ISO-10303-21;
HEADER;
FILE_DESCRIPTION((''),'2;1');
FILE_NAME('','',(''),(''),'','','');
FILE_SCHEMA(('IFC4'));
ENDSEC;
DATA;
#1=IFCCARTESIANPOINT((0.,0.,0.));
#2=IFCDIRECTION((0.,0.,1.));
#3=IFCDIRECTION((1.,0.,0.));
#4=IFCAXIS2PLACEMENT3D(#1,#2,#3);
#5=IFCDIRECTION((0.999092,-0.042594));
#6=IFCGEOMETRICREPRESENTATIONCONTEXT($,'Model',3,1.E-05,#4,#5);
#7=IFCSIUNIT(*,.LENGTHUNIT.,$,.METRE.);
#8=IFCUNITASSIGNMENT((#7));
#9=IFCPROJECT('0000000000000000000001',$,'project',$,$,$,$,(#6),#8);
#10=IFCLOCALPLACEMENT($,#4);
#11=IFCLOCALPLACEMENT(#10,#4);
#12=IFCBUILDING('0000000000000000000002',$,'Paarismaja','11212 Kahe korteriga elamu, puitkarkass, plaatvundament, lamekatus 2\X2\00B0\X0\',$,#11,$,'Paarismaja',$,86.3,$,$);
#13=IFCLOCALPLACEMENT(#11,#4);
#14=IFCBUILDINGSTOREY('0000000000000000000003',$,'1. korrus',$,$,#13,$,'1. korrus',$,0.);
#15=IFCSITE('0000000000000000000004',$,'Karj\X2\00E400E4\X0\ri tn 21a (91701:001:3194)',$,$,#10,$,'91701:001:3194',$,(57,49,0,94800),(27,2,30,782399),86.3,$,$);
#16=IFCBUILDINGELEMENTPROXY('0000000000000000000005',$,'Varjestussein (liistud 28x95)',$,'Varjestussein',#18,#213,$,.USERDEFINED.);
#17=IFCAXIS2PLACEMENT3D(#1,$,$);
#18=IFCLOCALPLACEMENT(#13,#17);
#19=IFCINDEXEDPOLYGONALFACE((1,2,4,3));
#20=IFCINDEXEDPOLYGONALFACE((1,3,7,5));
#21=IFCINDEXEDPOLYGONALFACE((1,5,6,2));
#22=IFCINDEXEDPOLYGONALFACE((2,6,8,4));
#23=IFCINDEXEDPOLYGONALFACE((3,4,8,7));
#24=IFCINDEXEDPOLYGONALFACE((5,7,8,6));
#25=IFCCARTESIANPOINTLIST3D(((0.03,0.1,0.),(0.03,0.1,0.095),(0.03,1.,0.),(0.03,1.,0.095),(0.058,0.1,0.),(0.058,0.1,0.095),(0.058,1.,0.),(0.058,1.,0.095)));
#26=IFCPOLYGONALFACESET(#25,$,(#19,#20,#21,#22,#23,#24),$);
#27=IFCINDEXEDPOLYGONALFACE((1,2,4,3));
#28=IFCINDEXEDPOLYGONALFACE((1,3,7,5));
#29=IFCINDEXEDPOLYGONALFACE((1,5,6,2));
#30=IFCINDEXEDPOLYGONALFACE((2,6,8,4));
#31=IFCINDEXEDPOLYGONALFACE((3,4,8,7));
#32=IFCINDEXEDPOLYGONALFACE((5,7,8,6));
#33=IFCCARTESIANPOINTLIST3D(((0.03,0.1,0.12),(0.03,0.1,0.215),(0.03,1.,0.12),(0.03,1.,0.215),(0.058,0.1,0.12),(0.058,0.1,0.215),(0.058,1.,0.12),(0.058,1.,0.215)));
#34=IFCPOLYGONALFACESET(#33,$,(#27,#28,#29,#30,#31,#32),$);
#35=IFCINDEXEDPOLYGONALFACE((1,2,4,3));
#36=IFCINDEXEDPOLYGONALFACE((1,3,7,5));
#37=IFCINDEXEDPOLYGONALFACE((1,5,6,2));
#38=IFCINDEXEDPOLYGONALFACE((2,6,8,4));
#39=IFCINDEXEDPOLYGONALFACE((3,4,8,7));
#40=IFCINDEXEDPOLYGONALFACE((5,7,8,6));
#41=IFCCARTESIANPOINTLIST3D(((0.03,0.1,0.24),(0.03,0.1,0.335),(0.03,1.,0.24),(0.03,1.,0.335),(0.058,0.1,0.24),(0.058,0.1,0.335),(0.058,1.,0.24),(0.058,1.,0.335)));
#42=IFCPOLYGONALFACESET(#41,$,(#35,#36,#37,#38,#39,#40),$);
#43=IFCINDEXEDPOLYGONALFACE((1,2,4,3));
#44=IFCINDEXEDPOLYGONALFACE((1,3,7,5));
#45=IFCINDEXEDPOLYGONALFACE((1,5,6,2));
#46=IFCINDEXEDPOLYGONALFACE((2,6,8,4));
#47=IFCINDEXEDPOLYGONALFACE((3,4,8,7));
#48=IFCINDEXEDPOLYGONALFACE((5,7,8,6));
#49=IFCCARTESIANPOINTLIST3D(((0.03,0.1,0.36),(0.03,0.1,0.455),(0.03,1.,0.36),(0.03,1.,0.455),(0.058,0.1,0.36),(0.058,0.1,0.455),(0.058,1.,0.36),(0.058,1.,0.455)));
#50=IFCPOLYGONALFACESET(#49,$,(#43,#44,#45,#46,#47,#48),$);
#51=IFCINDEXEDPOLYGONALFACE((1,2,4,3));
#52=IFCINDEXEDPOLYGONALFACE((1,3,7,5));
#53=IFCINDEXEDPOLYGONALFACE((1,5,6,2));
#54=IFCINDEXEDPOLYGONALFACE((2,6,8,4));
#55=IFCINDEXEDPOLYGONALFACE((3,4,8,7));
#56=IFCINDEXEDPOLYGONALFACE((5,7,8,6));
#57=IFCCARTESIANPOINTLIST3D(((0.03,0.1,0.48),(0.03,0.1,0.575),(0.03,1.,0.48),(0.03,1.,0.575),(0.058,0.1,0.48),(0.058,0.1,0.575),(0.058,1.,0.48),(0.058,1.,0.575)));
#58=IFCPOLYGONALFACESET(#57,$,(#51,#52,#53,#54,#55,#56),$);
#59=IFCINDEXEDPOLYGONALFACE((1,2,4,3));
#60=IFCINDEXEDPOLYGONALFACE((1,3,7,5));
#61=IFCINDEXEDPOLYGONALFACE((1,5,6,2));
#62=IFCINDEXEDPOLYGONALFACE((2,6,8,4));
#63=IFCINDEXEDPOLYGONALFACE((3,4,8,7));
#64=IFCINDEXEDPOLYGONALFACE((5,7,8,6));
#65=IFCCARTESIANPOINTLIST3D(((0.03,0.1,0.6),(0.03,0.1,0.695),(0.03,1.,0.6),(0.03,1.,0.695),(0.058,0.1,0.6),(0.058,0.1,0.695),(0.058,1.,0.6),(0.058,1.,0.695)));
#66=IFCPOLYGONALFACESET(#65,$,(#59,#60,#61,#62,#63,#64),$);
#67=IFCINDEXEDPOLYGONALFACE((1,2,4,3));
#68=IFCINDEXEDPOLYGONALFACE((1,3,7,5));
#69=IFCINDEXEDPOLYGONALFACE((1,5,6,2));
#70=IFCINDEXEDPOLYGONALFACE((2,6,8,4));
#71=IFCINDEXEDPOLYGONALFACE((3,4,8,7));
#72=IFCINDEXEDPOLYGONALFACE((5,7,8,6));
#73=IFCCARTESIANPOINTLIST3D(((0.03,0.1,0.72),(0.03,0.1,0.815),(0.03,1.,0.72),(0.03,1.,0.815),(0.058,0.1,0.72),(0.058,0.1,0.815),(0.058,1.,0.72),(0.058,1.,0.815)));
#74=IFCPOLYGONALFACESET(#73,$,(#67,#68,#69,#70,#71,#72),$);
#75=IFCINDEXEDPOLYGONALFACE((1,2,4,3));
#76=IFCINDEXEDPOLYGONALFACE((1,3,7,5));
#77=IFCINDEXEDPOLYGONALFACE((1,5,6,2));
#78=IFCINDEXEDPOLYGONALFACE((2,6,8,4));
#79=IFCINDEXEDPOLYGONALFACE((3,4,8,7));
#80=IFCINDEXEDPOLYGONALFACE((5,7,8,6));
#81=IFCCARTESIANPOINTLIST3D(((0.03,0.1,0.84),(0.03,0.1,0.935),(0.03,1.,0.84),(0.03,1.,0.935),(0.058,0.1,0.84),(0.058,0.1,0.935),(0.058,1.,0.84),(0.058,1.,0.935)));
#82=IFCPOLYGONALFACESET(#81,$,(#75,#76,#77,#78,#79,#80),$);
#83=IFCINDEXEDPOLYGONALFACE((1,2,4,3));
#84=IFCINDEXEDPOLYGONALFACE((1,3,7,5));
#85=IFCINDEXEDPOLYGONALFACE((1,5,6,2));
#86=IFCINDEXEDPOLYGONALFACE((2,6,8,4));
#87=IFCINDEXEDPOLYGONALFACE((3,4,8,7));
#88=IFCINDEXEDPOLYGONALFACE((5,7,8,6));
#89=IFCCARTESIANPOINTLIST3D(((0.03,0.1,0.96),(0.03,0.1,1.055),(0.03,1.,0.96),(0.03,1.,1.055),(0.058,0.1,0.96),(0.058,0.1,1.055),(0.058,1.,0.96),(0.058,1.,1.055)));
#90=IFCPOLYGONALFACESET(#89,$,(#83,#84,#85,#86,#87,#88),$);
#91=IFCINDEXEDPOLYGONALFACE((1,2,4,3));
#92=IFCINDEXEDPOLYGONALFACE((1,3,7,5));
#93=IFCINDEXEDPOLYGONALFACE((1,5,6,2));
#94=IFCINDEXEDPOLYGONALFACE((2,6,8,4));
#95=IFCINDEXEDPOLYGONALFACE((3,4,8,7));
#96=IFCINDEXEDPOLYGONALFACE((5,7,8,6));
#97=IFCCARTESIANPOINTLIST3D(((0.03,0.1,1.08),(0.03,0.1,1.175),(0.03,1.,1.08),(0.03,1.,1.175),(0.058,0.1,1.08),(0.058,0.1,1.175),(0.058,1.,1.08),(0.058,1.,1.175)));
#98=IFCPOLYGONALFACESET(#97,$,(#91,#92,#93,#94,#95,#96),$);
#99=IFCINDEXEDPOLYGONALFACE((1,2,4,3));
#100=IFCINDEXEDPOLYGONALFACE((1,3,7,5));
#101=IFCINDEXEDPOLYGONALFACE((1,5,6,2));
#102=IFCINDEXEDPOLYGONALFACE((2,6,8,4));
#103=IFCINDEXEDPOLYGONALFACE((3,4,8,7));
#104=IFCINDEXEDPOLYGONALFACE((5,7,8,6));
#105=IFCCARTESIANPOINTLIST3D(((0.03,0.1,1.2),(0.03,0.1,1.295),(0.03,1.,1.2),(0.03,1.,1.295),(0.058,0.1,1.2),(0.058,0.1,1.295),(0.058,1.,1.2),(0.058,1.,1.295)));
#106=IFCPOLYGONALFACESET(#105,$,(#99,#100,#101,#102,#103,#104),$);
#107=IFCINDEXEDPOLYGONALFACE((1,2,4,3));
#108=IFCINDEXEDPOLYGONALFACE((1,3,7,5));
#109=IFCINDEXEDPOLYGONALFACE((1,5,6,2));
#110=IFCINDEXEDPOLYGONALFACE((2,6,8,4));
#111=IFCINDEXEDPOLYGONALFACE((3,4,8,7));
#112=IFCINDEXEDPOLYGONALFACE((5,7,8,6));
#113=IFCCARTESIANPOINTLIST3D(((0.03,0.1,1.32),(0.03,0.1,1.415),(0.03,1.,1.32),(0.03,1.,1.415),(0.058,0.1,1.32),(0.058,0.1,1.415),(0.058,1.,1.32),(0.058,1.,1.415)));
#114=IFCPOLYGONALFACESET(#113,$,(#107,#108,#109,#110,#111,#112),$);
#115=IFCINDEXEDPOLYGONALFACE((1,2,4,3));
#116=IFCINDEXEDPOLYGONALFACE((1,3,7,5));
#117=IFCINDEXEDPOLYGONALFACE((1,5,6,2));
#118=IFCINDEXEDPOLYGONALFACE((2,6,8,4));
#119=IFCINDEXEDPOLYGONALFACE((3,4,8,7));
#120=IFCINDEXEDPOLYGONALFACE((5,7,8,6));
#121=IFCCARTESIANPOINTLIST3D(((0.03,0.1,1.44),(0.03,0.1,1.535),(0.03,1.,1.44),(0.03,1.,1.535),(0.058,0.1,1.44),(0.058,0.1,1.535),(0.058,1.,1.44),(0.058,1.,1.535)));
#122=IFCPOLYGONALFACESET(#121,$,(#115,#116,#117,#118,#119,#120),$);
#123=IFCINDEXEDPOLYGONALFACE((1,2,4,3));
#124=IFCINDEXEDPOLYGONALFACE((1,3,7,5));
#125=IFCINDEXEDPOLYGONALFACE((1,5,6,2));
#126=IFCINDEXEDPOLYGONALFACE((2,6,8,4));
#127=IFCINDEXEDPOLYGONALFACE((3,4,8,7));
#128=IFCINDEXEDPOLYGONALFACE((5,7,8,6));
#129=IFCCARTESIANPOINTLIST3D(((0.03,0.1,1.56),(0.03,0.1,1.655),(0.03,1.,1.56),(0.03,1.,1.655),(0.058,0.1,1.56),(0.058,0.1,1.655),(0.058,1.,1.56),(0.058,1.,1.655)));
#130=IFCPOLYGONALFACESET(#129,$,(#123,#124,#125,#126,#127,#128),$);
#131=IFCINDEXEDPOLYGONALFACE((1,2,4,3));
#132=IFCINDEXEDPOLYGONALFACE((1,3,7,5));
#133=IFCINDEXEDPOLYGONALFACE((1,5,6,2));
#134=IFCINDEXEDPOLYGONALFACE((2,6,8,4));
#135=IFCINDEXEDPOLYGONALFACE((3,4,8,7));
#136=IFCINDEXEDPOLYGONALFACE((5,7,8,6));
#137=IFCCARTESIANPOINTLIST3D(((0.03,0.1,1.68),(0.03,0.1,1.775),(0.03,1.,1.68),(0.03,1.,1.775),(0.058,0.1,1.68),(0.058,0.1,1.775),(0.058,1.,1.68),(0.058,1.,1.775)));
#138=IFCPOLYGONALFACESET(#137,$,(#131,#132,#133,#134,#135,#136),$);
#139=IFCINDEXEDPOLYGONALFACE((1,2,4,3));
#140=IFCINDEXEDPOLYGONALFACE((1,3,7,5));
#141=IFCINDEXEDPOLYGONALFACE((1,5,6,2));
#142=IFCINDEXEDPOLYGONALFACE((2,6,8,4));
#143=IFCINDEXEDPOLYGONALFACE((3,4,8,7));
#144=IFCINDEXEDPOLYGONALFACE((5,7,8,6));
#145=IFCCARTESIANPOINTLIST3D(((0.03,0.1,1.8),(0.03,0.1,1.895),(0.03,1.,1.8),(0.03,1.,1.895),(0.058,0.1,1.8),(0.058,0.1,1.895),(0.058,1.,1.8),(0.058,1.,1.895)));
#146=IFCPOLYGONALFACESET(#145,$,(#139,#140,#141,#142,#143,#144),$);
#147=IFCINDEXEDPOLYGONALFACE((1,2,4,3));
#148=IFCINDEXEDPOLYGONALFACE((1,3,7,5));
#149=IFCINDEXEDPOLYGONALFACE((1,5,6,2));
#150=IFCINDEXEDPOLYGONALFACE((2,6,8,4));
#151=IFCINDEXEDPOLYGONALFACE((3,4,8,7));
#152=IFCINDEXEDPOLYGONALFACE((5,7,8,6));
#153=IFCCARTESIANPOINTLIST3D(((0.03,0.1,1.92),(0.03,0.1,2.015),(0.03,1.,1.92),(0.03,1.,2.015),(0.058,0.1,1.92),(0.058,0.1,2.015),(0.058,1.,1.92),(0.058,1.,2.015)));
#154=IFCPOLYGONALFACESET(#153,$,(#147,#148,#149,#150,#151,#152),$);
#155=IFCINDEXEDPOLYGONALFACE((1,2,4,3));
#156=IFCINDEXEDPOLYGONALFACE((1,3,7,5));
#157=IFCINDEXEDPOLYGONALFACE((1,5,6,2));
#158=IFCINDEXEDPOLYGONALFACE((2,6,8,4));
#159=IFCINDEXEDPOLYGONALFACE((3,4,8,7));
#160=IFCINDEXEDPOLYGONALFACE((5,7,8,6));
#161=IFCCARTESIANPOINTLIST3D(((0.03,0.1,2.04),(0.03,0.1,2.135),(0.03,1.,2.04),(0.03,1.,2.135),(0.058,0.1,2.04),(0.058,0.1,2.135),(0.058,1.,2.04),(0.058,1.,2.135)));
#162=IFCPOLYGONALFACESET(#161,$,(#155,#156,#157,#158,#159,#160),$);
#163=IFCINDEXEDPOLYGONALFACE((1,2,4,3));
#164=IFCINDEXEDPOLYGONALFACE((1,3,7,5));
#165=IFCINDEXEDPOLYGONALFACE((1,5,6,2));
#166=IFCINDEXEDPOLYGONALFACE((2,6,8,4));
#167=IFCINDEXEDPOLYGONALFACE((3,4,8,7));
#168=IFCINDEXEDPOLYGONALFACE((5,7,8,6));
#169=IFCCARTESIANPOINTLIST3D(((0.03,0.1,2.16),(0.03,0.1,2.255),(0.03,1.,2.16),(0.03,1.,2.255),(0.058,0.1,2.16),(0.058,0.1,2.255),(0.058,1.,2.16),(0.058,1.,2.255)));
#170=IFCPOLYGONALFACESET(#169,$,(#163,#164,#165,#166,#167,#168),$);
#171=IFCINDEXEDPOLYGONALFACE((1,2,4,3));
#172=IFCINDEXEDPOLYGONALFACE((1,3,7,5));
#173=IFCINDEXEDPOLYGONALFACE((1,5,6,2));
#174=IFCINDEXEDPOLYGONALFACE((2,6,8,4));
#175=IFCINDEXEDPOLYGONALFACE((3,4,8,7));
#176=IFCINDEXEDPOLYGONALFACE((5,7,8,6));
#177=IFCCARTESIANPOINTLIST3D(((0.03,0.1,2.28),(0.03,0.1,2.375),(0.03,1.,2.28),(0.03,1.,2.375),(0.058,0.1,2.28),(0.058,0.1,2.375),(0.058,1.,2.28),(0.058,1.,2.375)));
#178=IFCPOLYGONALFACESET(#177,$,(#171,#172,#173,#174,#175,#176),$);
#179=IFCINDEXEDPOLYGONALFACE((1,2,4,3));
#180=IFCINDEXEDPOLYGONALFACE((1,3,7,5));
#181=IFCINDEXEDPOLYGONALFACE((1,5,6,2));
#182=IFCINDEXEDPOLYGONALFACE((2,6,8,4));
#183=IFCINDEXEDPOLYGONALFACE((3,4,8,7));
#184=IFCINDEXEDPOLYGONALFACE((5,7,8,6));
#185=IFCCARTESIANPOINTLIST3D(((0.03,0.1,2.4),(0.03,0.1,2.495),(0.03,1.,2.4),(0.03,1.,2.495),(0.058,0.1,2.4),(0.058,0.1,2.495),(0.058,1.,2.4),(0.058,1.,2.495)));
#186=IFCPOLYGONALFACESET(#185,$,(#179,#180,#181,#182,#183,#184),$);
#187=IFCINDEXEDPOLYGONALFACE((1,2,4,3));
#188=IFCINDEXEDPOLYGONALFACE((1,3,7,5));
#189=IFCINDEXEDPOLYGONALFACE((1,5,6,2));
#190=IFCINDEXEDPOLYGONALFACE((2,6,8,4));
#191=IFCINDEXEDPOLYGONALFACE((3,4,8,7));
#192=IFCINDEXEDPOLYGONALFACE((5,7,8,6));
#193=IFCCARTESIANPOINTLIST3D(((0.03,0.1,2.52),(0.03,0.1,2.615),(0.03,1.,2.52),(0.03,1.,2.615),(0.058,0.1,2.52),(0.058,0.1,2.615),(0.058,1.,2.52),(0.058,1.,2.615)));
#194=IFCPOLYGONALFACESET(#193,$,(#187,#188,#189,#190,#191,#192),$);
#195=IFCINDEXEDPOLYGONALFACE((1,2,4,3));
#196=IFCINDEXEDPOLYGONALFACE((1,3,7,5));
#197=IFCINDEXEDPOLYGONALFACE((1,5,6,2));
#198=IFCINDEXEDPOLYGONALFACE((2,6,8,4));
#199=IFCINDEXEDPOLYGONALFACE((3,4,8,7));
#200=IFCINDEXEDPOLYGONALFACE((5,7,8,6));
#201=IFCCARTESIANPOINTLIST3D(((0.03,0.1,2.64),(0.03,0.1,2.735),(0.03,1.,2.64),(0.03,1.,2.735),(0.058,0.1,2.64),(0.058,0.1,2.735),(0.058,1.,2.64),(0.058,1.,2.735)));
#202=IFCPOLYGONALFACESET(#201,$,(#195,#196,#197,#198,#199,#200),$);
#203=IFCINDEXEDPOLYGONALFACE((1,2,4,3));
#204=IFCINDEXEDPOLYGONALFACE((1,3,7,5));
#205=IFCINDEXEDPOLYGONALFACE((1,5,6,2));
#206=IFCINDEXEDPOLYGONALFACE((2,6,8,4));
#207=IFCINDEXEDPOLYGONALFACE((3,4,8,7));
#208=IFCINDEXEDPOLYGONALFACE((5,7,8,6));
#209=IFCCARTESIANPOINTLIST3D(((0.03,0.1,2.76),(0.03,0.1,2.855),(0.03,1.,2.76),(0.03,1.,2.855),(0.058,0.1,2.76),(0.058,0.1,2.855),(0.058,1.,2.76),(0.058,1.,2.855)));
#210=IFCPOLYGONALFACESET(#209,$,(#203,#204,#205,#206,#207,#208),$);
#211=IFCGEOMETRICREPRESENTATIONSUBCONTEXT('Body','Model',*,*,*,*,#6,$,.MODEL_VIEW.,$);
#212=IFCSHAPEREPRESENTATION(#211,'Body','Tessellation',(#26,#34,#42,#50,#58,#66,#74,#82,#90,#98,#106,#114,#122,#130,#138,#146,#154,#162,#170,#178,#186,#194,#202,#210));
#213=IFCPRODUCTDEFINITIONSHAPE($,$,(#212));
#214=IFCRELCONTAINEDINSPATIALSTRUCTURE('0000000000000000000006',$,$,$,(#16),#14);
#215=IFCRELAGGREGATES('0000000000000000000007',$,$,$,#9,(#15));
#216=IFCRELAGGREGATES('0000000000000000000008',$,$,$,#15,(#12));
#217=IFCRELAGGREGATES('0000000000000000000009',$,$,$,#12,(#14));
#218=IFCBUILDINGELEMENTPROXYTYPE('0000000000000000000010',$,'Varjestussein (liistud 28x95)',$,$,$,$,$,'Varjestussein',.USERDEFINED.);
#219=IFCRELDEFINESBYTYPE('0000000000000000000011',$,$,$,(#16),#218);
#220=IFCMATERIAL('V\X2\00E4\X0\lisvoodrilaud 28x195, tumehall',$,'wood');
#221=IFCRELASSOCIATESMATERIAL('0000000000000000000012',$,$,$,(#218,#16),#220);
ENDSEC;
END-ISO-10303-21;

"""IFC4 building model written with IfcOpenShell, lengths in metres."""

from ifc_helpers import new_model, si_unit, direction, frame, origin_with_axes, place, context, subcontext, project, spatial, indexed_curve, outline, extrude, material, type_object, element, save


model = new_model("IFC4")

# Units and contexts
model_context = context("Model", 3, precision=1e-05, world=origin_with_axes(), true_north=direction((0.999092, -0.042594)))
body_context = subcontext(model_context, "Body", "Model", "MODEL_VIEW")
ifc_project = project(units=[si_unit("LENGTHUNIT", "METRE")], contexts=[model_context])

# Site, building, storey
site_placement = place(None, origin_with_axes())
site = spatial("IfcSite", under=ifc_project, at=site_placement, Name="Karjääri tn 21a (91701:001:3194)", LongName="91701:001:3194", RefLatitude=(57, 49, 0, 94800), RefLongitude=(27, 2, 30, 782399), RefElevation=86.3)
building_placement = place(site_placement, origin_with_axes())
building = spatial("IfcBuilding", under=site, at=building_placement, Name="Paarismaja", Description="11212 Kahe korteriga elamu, puitkarkass, plaatvundament, lamekatus 2°", LongName="Paarismaja", ElevationOfRefHeight=86.3)
storey_placement = place(building_placement, origin_with_axes())
storey = spatial("IfcBuildingStorey", under=building, at=storey_placement, Name="1. korrus", LongName="1. korrus", Elevation=0.0)

# Building element proxy
ifc_material_1 = material(Name="Välisvoodrilaud 28x195, tumehall", Category="wood")
building_element_proxy_type_1 = type_object("IfcBuildingElementProxyType", Name="Varjestussein (liistud 28x95)", ElementType="Varjestussein", PredefinedType="USERDEFINED", material=ifc_material_1)
proxy_1_placement = place(storey_placement, origin_with_axes())
element("IfcBuildingElementProxy", 1, at=proxy_1_placement, inside=storey, type_object=building_element_proxy_type_1, material=ifc_material_1, Name="Varjestussein (liistud 28x95)", ObjectType="Varjestussein", PredefinedType="USERDEFINED", context=body_context, shape_type="SweptSolid", body=[
    extrude(outline(indexed_curve([(0.03, 0.1), (0.058, 0.1), (0.058, 1.0), (0.03, 1.0), (0.03, 0.1)], self_intersect=False)), origin_with_axes(), (0.0, 0.0, 1.0), 0.095),
    extrude(outline(indexed_curve([(0.03, 0.1), (0.058, 0.1), (0.058, 1.0), (0.03, 1.0), (0.03, 0.1)], self_intersect=False)), frame((0.0, 0.0, 0.12), z_axis=(0.0, 0.0, 1.0), x_axis=(1.0, 0.0, 0.0)), (0.0, 0.0, 1.0), 0.095),
    extrude(outline(indexed_curve([(0.03, 0.1), (0.058, 0.1), (0.058, 1.0), (0.03, 1.0), (0.03, 0.1)], self_intersect=False)), frame((0.0, 0.0, 0.24), z_axis=(0.0, 0.0, 1.0), x_axis=(1.0, 0.0, 0.0)), (0.0, 0.0, 1.0), 0.095),
    extrude(outline(indexed_curve([(0.03, 0.1), (0.058, 0.1), (0.058, 1.0), (0.03, 1.0), (0.03, 0.1)], self_intersect=False)), frame((0.0, 0.0, 0.36), z_axis=(0.0, 0.0, 1.0), x_axis=(1.0, 0.0, 0.0)), (0.0, 0.0, 1.0), 0.095),
    extrude(outline(indexed_curve([(0.03, 0.1), (0.058, 0.1), (0.058, 1.0), (0.03, 1.0), (0.03, 0.1)], self_intersect=False)), frame((0.0, 0.0, 0.48), z_axis=(0.0, 0.0, 1.0), x_axis=(1.0, 0.0, 0.0)), (0.0, 0.0, 1.0), 0.095),
    extrude(outline(indexed_curve([(0.03, 0.1), (0.058, 0.1), (0.058, 1.0), (0.03, 1.0), (0.03, 0.1)], self_intersect=False)), frame((0.0, 0.0, 0.6), z_axis=(0.0, 0.0, 1.0), x_axis=(1.0, 0.0, 0.0)), (0.0, 0.0, 1.0), 0.095),
    extrude(outline(indexed_curve([(0.03, 0.1), (0.058, 0.1), (0.058, 1.0), (0.03, 1.0), (0.03, 0.1)], self_intersect=False)), frame((0.0, 0.0, 0.72), z_axis=(0.0, 0.0, 1.0), x_axis=(1.0, 0.0, 0.0)), (0.0, 0.0, 1.0), 0.095),
    extrude(outline(indexed_curve([(0.03, 0.1), (0.058, 0.1), (0.058, 1.0), (0.03, 1.0), (0.03, 0.1)], self_intersect=False)), frame((0.0, 0.0, 0.84), z_axis=(0.0, 0.0, 1.0), x_axis=(1.0, 0.0, 0.0)), (0.0, 0.0, 1.0), 0.095),
    extrude(outline(indexed_curve([(0.03, 0.1), (0.058, 0.1), (0.058, 1.0), (0.03, 1.0), (0.03, 0.1)], self_intersect=False)), frame((0.0, 0.0, 0.96), z_axis=(0.0, 0.0, 1.0), x_axis=(1.0, 0.0, 0.0)), (0.0, 0.0, 1.0), 0.095),
    extrude(outline(indexed_curve([(0.03, 0.1), (0.058, 0.1), (0.058, 1.0), (0.03, 1.0), (0.03, 0.1)], self_intersect=False)), frame((0.0, 0.0, 1.08), z_axis=(0.0, 0.0, 1.0), x_axis=(1.0, 0.0, 0.0)), (0.0, 0.0, 1.0), 0.095),
    extrude(outline(indexed_curve([(0.03, 0.1), (0.058, 0.1), (0.058, 1.0), (0.03, 1.0), (0.03, 0.1)], self_intersect=False)), frame((0.0, 0.0, 1.2), z_axis=(0.0, 0.0, 1.0), x_axis=(1.0, 0.0, 0.0)), (0.0, 0.0, 1.0), 0.095),
    extrude(outline(indexed_curve([(0.03, 0.1), (0.058, 0.1), (0.058, 1.0), (0.03, 1.0), (0.03, 0.1)], self_intersect=False)), frame((0.0, 0.0, 1.32), z_axis=(0.0, 0.0, 1.0), x_axis=(1.0, 0.0, 0.0)), (0.0, 0.0, 1.0), 0.095),
    extrude(outline(indexed_curve([(0.03, 0.1), (0.058, 0.1), (0.058, 1.0), (0.03, 1.0), (0.03, 0.1)], self_intersect=False)), frame((0.0, 0.0, 1.44), z_axis=(0.0, 0.0, 1.0), x_axis=(1.0, 0.0, 0.0)), (0.0, 0.0, 1.0), 0.095),
    extrude(outline(indexed_curve([(0.03, 0.1), (0.058, 0.1), (0.058, 1.0), (0.03, 1.0), (0.03, 0.1)], self_intersect=False)), frame((0.0, 0.0, 1.56), z_axis=(0.0, 0.0, 1.0), x_axis=(1.0, 0.0, 0.0)), (0.0, 0.0, 1.0), 0.095),
    extrude(outline(indexed_curve([(0.03, 0.1), (0.058, 0.1), (0.058, 1.0), (0.03, 1.0), (0.03, 0.1)], self_intersect=False)), frame((0.0, 0.0, 1.68), z_axis=(0.0, 0.0, 1.0), x_axis=(1.0, 0.0, 0.0)), (0.0, 0.0, 1.0), 0.095),
    extrude(outline(indexed_curve([(0.03, 0.1), (0.058, 0.1), (0.058, 1.0), (0.03, 1.0), (0.03, 0.1)], self_intersect=False)), frame((0.0, 0.0, 1.8), z_axis=(0.0, 0.0, 1.0), x_axis=(1.0, 0.0, 0.0)), (0.0, 0.0, 1.0), 0.095),
    extrude(outline(indexed_curve([(0.03, 0.1), (0.058, 0.1), (0.058, 1.0), (0.03, 1.0), (0.03, 0.1)], self_intersect=False)), frame((0.0, 0.0, 1.92), z_axis=(0.0, 0.0, 1.0), x_axis=(1.0, 0.0, 0.0)), (0.0, 0.0, 1.0), 0.095),
    extrude(outline(indexed_curve([(0.03, 0.1), (0.058, 0.1), (0.058, 1.0), (0.03, 1.0), (0.03, 0.1)], self_intersect=False)), frame((0.0, 0.0, 2.04), z_axis=(0.0, 0.0, 1.0), x_axis=(1.0, 0.0, 0.0)), (0.0, 0.0, 1.0), 0.095),
    extrude(outline(indexed_curve([(0.03, 0.1), (0.058, 0.1), (0.058, 1.0), (0.03, 1.0), (0.03, 0.1)], self_intersect=False)), frame((0.0, 0.0, 2.16), z_axis=(0.0, 0.0, 1.0), x_axis=(1.0, 0.0, 0.0)), (0.0, 0.0, 1.0), 0.095),
    extrude(outline(indexed_curve([(0.03, 0.1), (0.058, 0.1), (0.058, 1.0), (0.03, 1.0), (0.03, 0.1)], self_intersect=False)), frame((0.0, 0.0, 2.28), z_axis=(0.0, 0.0, 1.0), x_axis=(1.0, 0.0, 0.0)), (0.0, 0.0, 1.0), 0.095),
    extrude(outline(indexed_curve([(0.03, 0.1), (0.058, 0.1), (0.058, 1.0), (0.03, 1.0), (0.03, 0.1)], self_intersect=False)), frame((0.0, 0.0, 2.4), z_axis=(0.0, 0.0, 1.0), x_axis=(1.0, 0.0, 0.0)), (0.0, 0.0, 1.0), 0.095),
    extrude(outline(indexed_curve([(0.03, 0.1), (0.058, 0.1), (0.058, 1.0), (0.03, 1.0), (0.03, 0.1)], self_intersect=False)), frame((0.0, 0.0, 2.52), z_axis=(0.0, 0.0, 1.0), x_axis=(1.0, 0.0, 0.0)), (0.0, 0.0, 1.0), 0.095),
    extrude(outline(indexed_curve([(0.03, 0.1), (0.058, 0.1), (0.058, 1.0), (0.03, 1.0), (0.03, 0.1)], self_intersect=False)), frame((0.0, 0.0, 2.64), z_axis=(0.0, 0.0, 1.0), x_axis=(1.0, 0.0, 0.0)), (0.0, 0.0, 1.0), 0.095),
    extrude(outline(indexed_curve([(0.03, 0.1), (0.058, 0.1), (0.058, 1.0), (0.03, 1.0), (0.03, 0.1)], self_intersect=False)), frame((0.0, 0.0, 2.76), z_axis=(0.0, 0.0, 1.0), x_axis=(1.0, 0.0, 0.0)), (0.0, 0.0, 1.0), 0.095),
])

save(model, "model.ifc")
